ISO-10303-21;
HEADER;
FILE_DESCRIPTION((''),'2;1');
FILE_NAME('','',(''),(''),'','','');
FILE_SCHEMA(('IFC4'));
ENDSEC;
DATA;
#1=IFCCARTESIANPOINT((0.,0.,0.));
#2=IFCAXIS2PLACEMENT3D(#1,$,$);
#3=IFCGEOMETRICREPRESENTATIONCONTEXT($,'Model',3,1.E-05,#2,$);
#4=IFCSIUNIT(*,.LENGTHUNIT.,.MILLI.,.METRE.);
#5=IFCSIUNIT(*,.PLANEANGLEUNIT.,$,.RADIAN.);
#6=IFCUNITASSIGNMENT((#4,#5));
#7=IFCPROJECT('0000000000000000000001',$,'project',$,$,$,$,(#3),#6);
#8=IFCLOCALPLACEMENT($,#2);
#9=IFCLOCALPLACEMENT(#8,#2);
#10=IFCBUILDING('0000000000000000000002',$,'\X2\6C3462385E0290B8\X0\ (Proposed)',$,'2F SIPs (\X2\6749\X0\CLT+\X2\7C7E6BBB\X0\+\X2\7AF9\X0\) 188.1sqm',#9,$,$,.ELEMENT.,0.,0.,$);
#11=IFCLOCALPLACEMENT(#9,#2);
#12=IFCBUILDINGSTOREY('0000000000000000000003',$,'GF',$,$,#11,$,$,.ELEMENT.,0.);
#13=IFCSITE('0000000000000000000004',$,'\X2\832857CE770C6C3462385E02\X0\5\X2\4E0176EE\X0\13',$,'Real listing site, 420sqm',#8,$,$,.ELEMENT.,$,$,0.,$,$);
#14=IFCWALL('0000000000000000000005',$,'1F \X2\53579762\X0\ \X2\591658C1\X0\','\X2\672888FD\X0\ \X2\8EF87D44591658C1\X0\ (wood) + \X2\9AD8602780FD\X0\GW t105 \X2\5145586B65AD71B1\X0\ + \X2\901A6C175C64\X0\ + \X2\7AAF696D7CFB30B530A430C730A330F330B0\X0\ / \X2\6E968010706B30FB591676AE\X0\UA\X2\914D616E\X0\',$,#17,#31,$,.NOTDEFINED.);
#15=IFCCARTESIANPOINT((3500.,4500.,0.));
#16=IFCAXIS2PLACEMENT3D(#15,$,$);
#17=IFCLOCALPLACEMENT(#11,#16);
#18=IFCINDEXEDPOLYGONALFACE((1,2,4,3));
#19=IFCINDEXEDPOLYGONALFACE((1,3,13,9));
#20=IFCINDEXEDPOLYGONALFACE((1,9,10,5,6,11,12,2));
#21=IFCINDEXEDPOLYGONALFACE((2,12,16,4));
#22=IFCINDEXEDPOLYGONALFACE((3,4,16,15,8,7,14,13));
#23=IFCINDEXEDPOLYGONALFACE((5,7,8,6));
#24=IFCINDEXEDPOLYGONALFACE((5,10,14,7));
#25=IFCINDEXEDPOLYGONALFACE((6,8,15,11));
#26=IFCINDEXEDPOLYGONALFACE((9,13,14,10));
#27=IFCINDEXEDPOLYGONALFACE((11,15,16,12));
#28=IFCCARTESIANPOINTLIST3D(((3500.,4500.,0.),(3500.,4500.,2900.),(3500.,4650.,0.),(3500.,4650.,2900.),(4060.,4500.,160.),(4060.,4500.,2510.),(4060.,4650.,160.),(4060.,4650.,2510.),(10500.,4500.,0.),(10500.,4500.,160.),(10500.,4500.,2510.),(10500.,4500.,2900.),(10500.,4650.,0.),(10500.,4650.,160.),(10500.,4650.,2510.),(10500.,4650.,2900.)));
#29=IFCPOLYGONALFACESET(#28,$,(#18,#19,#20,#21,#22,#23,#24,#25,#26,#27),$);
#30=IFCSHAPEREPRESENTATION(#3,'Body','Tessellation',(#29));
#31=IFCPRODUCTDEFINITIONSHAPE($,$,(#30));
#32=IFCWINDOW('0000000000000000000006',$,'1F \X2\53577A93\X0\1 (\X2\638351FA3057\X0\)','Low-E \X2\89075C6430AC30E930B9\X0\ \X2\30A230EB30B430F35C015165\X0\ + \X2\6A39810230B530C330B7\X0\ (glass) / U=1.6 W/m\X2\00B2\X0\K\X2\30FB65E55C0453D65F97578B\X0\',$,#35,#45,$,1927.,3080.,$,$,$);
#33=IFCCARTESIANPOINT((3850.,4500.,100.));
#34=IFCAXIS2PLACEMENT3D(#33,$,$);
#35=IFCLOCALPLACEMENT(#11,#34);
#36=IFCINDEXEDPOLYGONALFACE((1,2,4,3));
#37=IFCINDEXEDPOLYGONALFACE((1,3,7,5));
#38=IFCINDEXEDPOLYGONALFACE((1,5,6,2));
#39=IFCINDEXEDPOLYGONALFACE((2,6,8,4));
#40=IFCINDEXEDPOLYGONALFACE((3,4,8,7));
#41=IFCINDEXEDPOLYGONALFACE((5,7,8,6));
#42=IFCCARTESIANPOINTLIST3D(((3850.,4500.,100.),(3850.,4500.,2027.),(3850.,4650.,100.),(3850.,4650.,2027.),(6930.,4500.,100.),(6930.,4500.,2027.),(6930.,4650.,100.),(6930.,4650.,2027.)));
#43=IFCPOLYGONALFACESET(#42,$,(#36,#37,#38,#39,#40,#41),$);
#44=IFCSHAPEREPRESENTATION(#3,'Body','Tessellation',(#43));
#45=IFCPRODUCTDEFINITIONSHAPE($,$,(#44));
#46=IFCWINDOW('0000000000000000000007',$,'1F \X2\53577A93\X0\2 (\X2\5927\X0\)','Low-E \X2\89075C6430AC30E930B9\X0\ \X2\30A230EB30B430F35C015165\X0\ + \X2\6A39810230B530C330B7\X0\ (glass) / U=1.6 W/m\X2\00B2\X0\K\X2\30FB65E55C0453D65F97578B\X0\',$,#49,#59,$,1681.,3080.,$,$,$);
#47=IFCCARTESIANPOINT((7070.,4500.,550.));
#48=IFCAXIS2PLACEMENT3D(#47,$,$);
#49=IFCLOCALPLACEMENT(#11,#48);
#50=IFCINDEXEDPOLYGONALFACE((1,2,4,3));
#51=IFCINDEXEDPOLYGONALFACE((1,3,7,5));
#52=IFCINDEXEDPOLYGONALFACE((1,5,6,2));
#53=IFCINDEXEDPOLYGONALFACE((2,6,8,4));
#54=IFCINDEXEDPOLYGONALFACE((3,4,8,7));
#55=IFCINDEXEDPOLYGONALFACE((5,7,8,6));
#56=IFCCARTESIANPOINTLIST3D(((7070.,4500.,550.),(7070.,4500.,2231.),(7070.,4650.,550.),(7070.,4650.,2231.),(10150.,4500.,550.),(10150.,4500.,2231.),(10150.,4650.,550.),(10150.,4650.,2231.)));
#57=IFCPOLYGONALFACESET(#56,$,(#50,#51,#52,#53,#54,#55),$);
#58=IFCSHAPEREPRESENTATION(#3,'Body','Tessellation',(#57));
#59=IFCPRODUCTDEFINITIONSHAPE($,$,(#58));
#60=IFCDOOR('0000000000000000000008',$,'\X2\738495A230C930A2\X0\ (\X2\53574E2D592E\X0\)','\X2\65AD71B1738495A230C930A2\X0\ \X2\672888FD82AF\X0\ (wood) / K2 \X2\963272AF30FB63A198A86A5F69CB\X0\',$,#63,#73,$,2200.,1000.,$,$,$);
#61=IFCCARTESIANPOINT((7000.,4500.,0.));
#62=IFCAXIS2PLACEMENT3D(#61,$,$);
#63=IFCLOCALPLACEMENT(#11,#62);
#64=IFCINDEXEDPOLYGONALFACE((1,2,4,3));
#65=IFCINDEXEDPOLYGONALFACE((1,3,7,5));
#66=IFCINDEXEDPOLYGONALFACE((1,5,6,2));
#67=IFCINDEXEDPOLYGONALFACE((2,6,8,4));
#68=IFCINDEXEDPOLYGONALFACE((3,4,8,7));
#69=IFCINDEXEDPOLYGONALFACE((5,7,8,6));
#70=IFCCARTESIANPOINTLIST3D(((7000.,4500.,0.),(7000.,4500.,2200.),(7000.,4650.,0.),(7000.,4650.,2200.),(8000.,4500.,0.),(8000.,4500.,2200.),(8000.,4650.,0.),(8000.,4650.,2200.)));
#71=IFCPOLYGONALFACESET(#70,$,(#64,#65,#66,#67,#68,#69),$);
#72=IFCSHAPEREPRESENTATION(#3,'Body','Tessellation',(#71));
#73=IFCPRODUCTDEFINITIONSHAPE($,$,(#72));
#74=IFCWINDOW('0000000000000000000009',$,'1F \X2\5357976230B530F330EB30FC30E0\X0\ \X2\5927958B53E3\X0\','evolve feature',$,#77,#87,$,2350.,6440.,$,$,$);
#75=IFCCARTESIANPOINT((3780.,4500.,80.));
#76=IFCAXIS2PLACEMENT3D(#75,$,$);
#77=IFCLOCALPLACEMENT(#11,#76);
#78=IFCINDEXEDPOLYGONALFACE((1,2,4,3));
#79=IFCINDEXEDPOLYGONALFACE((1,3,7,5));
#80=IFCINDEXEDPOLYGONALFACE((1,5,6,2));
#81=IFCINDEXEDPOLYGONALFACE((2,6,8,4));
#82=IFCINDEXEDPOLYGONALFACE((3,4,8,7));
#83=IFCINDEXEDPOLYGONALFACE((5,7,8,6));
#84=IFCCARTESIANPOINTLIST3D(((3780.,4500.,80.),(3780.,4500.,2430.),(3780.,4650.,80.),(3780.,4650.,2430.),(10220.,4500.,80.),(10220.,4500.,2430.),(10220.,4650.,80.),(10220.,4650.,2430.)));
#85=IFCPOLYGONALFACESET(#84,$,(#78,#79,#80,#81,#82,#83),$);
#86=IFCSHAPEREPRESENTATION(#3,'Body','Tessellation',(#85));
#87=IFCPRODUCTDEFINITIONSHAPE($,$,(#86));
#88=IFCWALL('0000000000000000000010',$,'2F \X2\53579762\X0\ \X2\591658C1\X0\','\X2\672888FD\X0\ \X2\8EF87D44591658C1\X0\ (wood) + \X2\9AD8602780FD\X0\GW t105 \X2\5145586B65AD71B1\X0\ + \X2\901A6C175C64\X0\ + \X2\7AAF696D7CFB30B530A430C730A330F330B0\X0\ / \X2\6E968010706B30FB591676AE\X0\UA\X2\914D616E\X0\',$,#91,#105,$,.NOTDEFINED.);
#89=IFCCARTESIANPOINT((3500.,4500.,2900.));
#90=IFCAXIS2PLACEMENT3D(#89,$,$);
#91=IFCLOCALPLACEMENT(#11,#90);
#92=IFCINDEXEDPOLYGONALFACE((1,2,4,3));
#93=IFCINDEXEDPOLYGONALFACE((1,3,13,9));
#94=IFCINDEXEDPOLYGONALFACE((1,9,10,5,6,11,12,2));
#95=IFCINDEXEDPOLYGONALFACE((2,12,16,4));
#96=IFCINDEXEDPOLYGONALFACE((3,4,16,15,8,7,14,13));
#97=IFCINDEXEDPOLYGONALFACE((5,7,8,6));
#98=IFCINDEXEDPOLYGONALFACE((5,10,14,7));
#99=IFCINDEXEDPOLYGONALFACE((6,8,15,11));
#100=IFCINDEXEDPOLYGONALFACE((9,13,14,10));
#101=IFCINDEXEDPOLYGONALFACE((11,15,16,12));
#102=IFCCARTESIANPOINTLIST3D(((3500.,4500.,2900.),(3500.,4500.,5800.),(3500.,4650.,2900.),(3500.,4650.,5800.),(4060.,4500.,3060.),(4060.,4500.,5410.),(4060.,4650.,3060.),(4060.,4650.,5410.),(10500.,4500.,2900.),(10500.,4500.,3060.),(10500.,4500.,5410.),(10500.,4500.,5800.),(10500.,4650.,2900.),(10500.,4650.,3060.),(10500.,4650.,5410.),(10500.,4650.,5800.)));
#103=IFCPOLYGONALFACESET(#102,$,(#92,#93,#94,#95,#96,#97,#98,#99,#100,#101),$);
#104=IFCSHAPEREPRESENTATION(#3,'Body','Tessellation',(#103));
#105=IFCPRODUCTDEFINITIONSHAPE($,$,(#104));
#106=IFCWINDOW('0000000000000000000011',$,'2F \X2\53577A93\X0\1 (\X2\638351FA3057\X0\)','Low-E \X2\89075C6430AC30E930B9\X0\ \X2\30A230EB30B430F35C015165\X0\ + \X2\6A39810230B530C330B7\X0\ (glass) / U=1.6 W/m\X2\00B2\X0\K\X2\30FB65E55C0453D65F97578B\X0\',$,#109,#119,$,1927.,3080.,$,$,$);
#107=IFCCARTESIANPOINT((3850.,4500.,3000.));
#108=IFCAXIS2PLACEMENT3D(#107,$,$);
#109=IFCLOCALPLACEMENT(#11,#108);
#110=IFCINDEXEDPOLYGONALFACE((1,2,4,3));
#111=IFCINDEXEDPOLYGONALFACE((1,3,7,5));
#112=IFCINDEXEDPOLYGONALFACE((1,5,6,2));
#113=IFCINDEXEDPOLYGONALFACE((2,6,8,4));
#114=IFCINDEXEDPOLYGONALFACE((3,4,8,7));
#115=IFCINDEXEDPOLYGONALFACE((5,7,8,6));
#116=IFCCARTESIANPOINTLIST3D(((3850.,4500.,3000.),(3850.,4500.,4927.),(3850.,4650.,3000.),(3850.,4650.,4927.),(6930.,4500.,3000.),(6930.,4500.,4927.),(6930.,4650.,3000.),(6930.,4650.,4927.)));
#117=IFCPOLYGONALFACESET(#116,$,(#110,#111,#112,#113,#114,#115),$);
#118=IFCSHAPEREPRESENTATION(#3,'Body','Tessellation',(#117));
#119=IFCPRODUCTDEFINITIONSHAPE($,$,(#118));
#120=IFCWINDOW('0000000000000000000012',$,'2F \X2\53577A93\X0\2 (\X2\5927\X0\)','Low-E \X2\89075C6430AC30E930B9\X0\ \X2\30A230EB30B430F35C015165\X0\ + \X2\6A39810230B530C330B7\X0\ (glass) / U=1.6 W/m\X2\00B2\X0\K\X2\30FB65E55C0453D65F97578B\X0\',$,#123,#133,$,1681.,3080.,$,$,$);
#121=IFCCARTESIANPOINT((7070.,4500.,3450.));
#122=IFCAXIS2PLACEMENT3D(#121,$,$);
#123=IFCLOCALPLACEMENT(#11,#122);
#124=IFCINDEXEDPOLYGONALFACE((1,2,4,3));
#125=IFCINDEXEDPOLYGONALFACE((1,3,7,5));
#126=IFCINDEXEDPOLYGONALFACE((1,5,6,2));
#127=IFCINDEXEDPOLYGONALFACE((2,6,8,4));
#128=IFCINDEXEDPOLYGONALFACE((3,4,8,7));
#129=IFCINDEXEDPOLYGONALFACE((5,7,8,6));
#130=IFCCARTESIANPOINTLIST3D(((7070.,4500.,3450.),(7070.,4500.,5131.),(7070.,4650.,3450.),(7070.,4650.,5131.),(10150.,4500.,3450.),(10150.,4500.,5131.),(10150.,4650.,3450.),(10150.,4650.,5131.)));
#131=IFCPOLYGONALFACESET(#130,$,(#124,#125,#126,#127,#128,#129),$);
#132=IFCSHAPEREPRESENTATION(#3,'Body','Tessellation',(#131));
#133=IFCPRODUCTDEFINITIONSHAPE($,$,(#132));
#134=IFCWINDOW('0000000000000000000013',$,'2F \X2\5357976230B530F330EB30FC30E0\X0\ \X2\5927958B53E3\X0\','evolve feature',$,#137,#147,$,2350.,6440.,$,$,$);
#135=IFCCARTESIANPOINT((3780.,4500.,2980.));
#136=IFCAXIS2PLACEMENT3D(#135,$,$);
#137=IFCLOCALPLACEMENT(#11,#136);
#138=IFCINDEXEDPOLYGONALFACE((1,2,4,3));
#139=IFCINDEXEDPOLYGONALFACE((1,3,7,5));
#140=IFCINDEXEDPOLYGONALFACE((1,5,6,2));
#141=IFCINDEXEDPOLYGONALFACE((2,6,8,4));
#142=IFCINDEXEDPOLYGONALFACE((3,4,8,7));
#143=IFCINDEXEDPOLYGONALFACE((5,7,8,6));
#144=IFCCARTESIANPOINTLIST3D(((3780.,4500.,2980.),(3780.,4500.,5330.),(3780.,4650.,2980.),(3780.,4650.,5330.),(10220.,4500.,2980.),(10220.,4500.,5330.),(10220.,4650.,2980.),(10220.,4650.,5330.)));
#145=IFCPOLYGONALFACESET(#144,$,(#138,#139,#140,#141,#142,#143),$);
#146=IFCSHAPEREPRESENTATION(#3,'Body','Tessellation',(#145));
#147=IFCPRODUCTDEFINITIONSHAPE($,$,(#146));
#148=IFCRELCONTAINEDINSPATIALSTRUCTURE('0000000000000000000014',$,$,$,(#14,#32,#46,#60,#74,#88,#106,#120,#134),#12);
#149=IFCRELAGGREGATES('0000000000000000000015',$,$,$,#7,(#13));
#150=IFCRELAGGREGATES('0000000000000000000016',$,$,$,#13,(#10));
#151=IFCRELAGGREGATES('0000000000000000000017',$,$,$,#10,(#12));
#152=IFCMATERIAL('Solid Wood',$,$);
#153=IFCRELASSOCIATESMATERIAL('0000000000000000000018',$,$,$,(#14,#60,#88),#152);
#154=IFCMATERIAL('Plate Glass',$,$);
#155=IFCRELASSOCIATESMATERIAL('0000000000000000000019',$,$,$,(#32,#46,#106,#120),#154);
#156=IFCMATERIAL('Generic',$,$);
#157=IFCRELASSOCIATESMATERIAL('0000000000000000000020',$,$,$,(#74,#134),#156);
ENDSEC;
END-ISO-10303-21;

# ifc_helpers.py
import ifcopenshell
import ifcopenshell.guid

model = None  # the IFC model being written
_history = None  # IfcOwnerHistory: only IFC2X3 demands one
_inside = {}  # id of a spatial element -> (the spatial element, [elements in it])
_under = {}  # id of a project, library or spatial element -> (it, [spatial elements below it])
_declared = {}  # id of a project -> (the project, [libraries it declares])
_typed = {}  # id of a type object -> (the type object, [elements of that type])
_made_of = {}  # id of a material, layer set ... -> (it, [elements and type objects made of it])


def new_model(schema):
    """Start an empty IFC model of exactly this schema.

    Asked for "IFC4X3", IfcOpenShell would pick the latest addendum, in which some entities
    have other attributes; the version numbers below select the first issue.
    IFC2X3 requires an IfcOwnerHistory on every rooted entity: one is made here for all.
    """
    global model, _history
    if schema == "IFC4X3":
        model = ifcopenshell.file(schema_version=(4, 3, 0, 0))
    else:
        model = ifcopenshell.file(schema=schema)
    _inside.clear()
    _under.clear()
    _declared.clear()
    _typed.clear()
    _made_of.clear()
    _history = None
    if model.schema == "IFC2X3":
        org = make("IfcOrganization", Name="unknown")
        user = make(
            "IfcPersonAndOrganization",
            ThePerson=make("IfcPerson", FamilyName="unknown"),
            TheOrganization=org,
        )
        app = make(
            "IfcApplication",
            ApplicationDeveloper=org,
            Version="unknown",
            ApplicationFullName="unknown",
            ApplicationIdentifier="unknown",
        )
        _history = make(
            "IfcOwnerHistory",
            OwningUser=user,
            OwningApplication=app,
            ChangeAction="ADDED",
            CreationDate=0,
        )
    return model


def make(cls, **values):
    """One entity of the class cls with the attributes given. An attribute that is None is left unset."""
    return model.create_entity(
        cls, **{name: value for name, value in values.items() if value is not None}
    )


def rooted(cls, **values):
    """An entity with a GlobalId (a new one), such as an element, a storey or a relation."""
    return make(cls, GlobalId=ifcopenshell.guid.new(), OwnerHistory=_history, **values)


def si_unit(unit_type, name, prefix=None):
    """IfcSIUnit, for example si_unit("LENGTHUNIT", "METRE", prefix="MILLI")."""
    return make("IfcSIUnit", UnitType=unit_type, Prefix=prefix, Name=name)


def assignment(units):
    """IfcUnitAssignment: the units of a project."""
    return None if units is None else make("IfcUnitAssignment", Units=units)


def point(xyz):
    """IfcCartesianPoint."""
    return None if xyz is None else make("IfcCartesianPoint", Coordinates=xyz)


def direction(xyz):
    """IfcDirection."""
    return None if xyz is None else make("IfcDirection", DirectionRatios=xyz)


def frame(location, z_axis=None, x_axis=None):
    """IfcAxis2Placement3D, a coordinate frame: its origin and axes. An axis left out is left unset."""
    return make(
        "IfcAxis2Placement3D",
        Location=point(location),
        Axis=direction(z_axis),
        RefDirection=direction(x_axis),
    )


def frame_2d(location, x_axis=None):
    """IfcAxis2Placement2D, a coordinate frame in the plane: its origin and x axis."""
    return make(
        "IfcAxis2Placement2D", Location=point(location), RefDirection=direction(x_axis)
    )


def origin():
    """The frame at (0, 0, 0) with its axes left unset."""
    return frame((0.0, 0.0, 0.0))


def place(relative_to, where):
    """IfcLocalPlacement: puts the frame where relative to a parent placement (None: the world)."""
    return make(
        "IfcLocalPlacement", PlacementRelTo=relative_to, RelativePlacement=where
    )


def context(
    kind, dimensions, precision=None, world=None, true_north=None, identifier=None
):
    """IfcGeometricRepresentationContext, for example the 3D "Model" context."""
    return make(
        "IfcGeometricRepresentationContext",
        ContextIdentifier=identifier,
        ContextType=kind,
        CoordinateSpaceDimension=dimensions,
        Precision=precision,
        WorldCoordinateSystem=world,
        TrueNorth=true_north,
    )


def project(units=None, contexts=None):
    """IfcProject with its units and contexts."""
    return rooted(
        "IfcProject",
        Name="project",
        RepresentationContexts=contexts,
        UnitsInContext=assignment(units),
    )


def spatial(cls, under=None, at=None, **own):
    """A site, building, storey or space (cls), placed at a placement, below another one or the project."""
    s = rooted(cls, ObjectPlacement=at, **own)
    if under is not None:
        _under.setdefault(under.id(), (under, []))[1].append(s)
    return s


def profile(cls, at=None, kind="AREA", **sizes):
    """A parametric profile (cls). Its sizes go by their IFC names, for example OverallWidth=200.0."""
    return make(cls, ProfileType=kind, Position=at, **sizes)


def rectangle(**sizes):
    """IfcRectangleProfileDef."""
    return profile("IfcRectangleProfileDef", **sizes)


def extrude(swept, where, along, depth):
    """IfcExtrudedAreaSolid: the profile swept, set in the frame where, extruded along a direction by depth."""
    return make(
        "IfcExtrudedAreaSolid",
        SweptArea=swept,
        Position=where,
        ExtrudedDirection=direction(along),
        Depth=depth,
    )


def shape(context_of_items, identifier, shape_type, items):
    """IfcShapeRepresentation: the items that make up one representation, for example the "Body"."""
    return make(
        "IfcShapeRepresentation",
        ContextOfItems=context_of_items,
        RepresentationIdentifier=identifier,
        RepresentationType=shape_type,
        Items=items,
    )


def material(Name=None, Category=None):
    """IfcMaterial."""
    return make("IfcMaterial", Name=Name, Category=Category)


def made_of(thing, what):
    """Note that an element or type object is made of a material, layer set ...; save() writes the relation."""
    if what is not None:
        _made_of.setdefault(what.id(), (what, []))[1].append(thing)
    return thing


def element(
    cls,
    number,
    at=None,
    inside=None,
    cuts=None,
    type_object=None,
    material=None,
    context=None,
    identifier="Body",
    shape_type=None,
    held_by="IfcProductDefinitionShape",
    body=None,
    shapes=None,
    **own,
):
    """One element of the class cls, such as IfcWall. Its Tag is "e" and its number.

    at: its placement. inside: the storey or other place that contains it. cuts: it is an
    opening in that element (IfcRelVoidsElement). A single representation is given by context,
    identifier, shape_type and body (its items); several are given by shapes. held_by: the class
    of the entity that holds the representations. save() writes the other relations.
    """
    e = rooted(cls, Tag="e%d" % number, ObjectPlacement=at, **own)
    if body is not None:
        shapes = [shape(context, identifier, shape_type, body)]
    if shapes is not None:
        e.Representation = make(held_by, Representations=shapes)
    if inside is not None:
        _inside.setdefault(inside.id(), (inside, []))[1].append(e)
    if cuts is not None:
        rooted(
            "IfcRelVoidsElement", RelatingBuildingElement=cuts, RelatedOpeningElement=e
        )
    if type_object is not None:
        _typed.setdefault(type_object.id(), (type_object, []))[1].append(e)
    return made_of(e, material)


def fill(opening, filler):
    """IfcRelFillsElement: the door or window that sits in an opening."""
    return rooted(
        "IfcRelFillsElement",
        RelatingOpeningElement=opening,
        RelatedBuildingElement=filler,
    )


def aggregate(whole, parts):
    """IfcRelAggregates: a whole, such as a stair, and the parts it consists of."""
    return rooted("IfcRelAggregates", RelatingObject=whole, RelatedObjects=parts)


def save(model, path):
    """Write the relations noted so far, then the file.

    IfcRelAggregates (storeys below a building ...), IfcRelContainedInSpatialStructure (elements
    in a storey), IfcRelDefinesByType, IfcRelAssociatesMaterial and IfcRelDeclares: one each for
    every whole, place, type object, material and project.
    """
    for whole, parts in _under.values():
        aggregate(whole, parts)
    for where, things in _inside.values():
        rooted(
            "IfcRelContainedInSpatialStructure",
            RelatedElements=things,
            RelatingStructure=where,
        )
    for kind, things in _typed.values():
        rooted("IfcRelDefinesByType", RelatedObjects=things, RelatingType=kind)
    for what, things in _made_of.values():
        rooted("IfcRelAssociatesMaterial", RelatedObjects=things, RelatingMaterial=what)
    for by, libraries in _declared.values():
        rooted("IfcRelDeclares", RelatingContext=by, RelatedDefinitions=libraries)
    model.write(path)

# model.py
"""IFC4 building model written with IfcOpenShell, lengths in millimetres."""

from ifc_helpers import new_model, si_unit, frame, frame_2d, origin, place, context, project, spatial, rectangle, extrude, material, element, fill, save


model = new_model("IFC4")

# Units and contexts
model_context = context("Model", 3, precision=1e-05, world=origin())
ifc_project = project(units=[si_unit("LENGTHUNIT", "METRE", prefix="MILLI"), si_unit("PLANEANGLEUNIT", "RADIAN")], contexts=[model_context])

# Site, building, storey
site_placement = place(None, origin())
site = spatial("IfcSite", under=ifc_project, at=site_placement, Name="茨城県水戸市5丁目13", ObjectType="Real listing site, 420sqm", CompositionType="ELEMENT", RefElevation=0.0)
building_placement = place(site_placement, origin())
building = spatial("IfcBuilding", under=site, at=building_placement, Name="水戸市邸 (Proposed)", ObjectType="2F SIPs (杉CLT+籾殻+竹) 188.1sqm", CompositionType="ELEMENT", ElevationOfRefHeight=0.0, ElevationOfTerrain=0.0)
storey_placement = place(building_placement, origin())
storey = spatial("IfcBuildingStorey", under=building, at=storey_placement, Name="GF", CompositionType="ELEMENT", Elevation=0.0)

# Shared definitions
ifc_material_1 = material(Name="Solid Wood")

# Wall, openings, windows, door
wall_1_placement = place(storey_placement, frame((3500.0, 4500.0, 0.0)))
wall_1 = element("IfcWall", 1, at=wall_1_placement, inside=storey, material=ifc_material_1, Name="1F 南面 外壁", Description="木製 軸組外壁 (wood) + 高性能GW t105 充填断熱 + 通気層 + 窯業系サイディング / 準耐火・外皮UA配慮", PredefinedType="NOTDEFINED", context=model_context, shape_type="SweptSolid", body=[
    extrude(rectangle(XDim=7000.0, YDim=150.0, at=frame_2d((3500.0, 75.0))), frame((3500.0, 4500.0, 0.0)), (0.0, 0.0, 1.0), 2900.0),
])
opening_1_placement = place(storey_placement, frame((3850.0, 4500.0, 100.0)))
opening_1 = element("IfcOpeningElement", 2, at=opening_1_placement, cuts=wall_1, PredefinedType="NOTDEFINED", context=model_context, shape_type="SweptSolid", body=[
    extrude(rectangle(XDim=3080.0, YDim=150.0, at=frame_2d((1540.0, 75.0))), frame((3850.0, 4500.0, 100.0)), (0.0, 0.0, 1.0), 1927.0),
])
opening_2_placement = place(storey_placement, frame((7070.0, 4500.0, 550.0)))
opening_2 = element("IfcOpeningElement", 3, at=opening_2_placement, cuts=wall_1, PredefinedType="NOTDEFINED", context=model_context, shape_type="SweptSolid", body=[
    extrude(rectangle(XDim=3080.0, YDim=150.0, at=frame_2d((1540.0, 75.0))), frame((7070.0, 4500.0, 550.0)), (0.0, 0.0, 1.0), 1681.0),
])
opening_3_placement = place(storey_placement, frame((7000.0, 4500.0, 0.0)))
opening_3 = element("IfcOpeningElement", 4, at=opening_3_placement, cuts=wall_1, PredefinedType="NOTDEFINED", context=model_context, shape_type="SweptSolid", body=[
    extrude(rectangle(XDim=1000.0, YDim=150.0, at=frame_2d((500.0, 75.0))), frame((7000.0, 4500.0, 0.0)), (0.0, 0.0, 1.0), 2200.0),
])
opening_4_placement = place(storey_placement, frame((3780.0, 4500.0, 80.0)))
opening_4 = element("IfcOpeningElement", 5, at=opening_4_placement, cuts=wall_1, PredefinedType="NOTDEFINED", context=model_context, shape_type="SweptSolid", body=[
    extrude(rectangle(XDim=6440.0, YDim=150.0, at=frame_2d((3220.0, 75.0))), frame((3780.0, 4500.0, 80.0)), (0.0, 0.0, 1.0), 2350.0),
])
ifc_material_2 = material(Name="Plate Glass")
window_1_placement = place(storey_placement, frame((3850.0, 4500.0, 100.0)))
window_1 = element("IfcWindow", 6, at=window_1_placement, inside=storey, material=ifc_material_2, Name="1F 南窓1 (掃出し)", Description="Low-E 複層ガラス アルゴン封入 + 樹脂サッシ (glass) / U=1.6 W/m²K・日射取得型", OverallHeight=1927.0, OverallWidth=3080.0, context=model_context, shape_type="SweptSolid", body=[
    extrude(rectangle(XDim=3080.0, YDim=150.0, at=frame_2d((1540.0, 75.0))), frame((3850.0, 4500.0, 100.0)), (0.0, 0.0, 1.0), 1927.0),
])
fill(opening_1, window_1)
window_2_placement = place(storey_placement, frame((7070.0, 4500.0, 550.0)))
window_2 = element("IfcWindow", 7, at=window_2_placement, inside=storey, material=ifc_material_2, Name="1F 南窓2 (大)", Description="Low-E 複層ガラス アルゴン封入 + 樹脂サッシ (glass) / U=1.6 W/m²K・日射取得型", OverallHeight=1681.0, OverallWidth=3080.0, context=model_context, shape_type="SweptSolid", body=[
    extrude(rectangle(XDim=3080.0, YDim=150.0, at=frame_2d((1540.0, 75.0))), frame((7070.0, 4500.0, 550.0)), (0.0, 0.0, 1.0), 1681.0),
])
fill(opening_2, window_2)
door_placement = place(storey_placement, frame((7000.0, 4500.0, 0.0)))
door = element("IfcDoor", 8, at=door_placement, inside=storey, material=ifc_material_1, Name="玄関ドア (南中央)", Description="断熱玄関ドア 木製芯 (wood) / K2 防犯・採風機構", OverallHeight=2200.0, OverallWidth=1000.0, context=model_context, shape_type="SweptSolid", body=[
    extrude(rectangle(XDim=1000.0, YDim=150.0, at=frame_2d((500.0, 75.0))), frame((7000.0, 4500.0, 0.0)), (0.0, 0.0, 1.0), 2200.0),
])
fill(opening_3, door)
ifc_material_3 = material(Name="Generic")
window_3_placement = place(storey_placement, frame((3780.0, 4500.0, 80.0)))
window_3 = element("IfcWindow", 9, at=window_3_placement, inside=storey, material=ifc_material_3, Name="1F 南面サンルーム 大開口", Description="evolve feature", OverallHeight=2350.0, OverallWidth=6440.0, context=model_context, shape_type="SweptSolid", body=[
    extrude(rectangle(XDim=6440.0, YDim=150.0, at=frame_2d((3220.0, 75.0))), frame((3780.0, 4500.0, 80.0)), (0.0, 0.0, 1.0), 2350.0),
])
fill(opening_4, window_3)

# Wall, openings, windows
wall_2_placement = place(storey_placement, frame((3500.0, 4500.0, 2900.0)))
wall_2 = element("IfcWall", 10, at=wall_2_placement, inside=storey, material=ifc_material_1, Name="2F 南面 外壁", Description="木製 軸組外壁 (wood) + 高性能GW t105 充填断熱 + 通気層 + 窯業系サイディング / 準耐火・外皮UA配慮", PredefinedType="NOTDEFINED", context=model_context, shape_type="SweptSolid", body=[
    extrude(rectangle(XDim=7000.0, YDim=150.0, at=frame_2d((3500.0, 75.0))), frame((3500.0, 4500.0, 2900.0)), (0.0, 0.0, 1.0), 2900.0),
])
opening_5_placement = place(storey_placement, frame((3850.0, 4500.0, 3000.0)))
opening_5 = element("IfcOpeningElement", 11, at=opening_5_placement, cuts=wall_2, PredefinedType="NOTDEFINED", context=model_context, shape_type="SweptSolid", body=[
    extrude(rectangle(XDim=3080.0, YDim=150.0, at=frame_2d((1540.0, 75.0))), frame((3850.0, 4500.0, 3000.0)), (0.0, 0.0, 1.0), 1927.0),
])
opening_6_placement = place(storey_placement, frame((7070.0, 4500.0, 3450.0)))
opening_6 = element("IfcOpeningElement", 12, at=opening_6_placement, cuts=wall_2, PredefinedType="NOTDEFINED", context=model_context, shape_type="SweptSolid", body=[
    extrude(rectangle(XDim=3080.0, YDim=150.0, at=frame_2d((1540.0, 75.0))), frame((7070.0, 4500.0, 3450.0)), (0.0, 0.0, 1.0), 1681.0),
])
opening_7_placement = place(storey_placement, frame((3780.0, 4500.0, 2980.0)))
opening_7 = element("IfcOpeningElement", 13, at=opening_7_placement, cuts=wall_2, PredefinedType="NOTDEFINED", context=model_context, shape_type="SweptSolid", body=[
    extrude(rectangle(XDim=6440.0, YDim=150.0, at=frame_2d((3220.0, 75.0))), frame((3780.0, 4500.0, 2980.0)), (0.0, 0.0, 1.0), 2350.0),
])
window_4_placement = place(storey_placement, frame((3850.0, 4500.0, 3000.0)))
window_4 = element("IfcWindow", 14, at=window_4_placement, inside=storey, material=ifc_material_2, Name="2F 南窓1 (掃出し)", Description="Low-E 複層ガラス アルゴン封入 + 樹脂サッシ (glass) / U=1.6 W/m²K・日射取得型", OverallHeight=1927.0, OverallWidth=3080.0, context=model_context, shape_type="SweptSolid", body=[
    extrude(rectangle(XDim=3080.0, YDim=150.0, at=frame_2d((1540.0, 75.0))), frame((3850.0, 4500.0, 3000.0)), (0.0, 0.0, 1.0), 1927.0),
])
fill(opening_5, window_4)
window_5_placement = place(storey_placement, frame((7070.0, 4500.0, 3450.0)))
window_5 = element("IfcWindow", 15, at=window_5_placement, inside=storey, material=ifc_material_2, Name="2F 南窓2 (大)", Description="Low-E 複層ガラス アルゴン封入 + 樹脂サッシ (glass) / U=1.6 W/m²K・日射取得型", OverallHeight=1681.0, OverallWidth=3080.0, context=model_context, shape_type="SweptSolid", body=[
    extrude(rectangle(XDim=3080.0, YDim=150.0, at=frame_2d((1540.0, 75.0))), frame((7070.0, 4500.0, 3450.0)), (0.0, 0.0, 1.0), 1681.0),
])
fill(opening_6, window_5)
window_6_placement = place(storey_placement, frame((3780.0, 4500.0, 2980.0)))
window_6 = element("IfcWindow", 16, at=window_6_placement, inside=storey, material=ifc_material_3, Name="2F 南面サンルーム 大開口", Description="evolve feature", OverallHeight=2350.0, OverallWidth=6440.0, context=model_context, shape_type="SweptSolid", body=[
    extrude(rectangle(XDim=6440.0, YDim=150.0, at=frame_2d((3220.0, 75.0))), frame((3780.0, 4500.0, 2980.0)), (0.0, 0.0, 1.0), 2350.0),
])
fill(opening_7, window_6)

save(model, "model.ifc")
